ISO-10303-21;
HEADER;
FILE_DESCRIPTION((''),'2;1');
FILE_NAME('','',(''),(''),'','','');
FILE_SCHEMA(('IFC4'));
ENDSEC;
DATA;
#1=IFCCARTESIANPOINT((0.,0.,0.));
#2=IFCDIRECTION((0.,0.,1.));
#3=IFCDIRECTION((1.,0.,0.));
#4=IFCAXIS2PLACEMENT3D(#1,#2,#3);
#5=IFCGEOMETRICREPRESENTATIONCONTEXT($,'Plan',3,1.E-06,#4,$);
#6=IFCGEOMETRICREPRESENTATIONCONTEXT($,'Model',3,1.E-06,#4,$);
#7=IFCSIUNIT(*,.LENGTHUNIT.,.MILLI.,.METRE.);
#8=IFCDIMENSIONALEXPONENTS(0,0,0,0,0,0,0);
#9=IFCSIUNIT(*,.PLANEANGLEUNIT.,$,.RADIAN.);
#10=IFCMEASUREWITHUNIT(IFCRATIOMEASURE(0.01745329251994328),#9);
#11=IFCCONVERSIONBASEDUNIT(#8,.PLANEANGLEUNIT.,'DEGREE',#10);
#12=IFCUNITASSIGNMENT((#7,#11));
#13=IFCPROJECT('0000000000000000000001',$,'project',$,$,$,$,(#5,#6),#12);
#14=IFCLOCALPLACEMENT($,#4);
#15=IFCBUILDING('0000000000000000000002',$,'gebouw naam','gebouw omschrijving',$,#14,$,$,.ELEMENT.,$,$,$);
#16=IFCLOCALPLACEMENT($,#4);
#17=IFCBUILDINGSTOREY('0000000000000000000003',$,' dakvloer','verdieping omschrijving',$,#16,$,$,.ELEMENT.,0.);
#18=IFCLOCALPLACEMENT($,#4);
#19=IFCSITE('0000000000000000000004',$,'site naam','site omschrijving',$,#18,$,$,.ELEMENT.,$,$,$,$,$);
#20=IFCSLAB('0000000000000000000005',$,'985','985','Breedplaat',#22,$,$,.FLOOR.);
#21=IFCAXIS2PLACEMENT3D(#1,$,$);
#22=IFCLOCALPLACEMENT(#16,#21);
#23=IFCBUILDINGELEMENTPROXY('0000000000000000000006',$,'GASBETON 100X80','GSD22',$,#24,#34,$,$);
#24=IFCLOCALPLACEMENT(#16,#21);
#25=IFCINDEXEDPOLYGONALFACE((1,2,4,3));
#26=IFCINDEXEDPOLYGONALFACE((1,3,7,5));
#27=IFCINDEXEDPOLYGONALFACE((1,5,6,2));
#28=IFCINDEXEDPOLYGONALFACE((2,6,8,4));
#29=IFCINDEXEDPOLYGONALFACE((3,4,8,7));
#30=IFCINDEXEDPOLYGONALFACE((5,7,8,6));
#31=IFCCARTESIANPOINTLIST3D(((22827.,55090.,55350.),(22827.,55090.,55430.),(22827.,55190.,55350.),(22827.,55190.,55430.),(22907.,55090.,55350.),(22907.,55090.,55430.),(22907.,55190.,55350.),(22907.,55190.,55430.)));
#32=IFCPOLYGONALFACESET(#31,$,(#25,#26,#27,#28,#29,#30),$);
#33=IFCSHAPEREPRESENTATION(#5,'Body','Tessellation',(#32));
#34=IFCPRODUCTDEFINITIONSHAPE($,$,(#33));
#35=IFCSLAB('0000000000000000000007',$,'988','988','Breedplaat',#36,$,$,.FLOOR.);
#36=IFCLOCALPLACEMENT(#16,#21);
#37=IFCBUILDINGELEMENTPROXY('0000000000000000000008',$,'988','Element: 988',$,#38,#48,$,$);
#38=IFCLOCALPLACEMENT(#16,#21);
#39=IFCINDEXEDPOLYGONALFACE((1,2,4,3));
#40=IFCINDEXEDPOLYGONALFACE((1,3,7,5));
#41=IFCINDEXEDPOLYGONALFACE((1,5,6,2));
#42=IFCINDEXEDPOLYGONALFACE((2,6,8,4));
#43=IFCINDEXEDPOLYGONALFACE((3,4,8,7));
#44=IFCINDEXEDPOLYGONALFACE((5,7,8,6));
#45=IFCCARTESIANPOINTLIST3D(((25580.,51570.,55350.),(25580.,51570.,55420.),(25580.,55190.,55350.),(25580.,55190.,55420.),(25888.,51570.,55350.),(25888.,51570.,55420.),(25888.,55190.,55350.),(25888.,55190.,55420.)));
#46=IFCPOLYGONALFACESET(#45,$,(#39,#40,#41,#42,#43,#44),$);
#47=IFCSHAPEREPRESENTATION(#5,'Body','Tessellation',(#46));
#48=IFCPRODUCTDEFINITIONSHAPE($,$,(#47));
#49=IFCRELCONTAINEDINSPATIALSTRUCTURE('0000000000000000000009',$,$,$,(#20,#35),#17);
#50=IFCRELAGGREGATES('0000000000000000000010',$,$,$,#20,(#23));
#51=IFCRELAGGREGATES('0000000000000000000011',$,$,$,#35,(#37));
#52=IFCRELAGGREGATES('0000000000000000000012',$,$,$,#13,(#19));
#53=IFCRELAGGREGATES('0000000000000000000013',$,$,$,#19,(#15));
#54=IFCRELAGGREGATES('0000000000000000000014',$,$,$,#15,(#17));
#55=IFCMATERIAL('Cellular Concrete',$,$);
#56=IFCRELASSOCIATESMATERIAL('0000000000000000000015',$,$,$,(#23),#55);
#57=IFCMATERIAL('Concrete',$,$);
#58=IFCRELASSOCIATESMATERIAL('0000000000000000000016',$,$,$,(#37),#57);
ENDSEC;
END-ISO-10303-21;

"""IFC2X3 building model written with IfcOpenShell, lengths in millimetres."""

from ifc_helpers import new_model, entity, si_unit, converted_unit, frame, origin_with_axes, origin_2d_with_axis, place, context, project, spatial, polyline, rectangle, outline, extrude, material, element, aggregate, save


model = new_model("IFC2X3")

# Units and contexts
plan_context = context("Plan", 3, precision=1e-06, world=origin_with_axes())
model_context = context("Model", 3, precision=1e-06, world=origin_with_axes())
ifc_project = project(units=[si_unit("LENGTHUNIT", "METRE", prefix="MILLI"), converted_unit("PLANEANGLEUNIT", "DEGREE", entity("IfcRatioMeasure", 0.01745329251994328), si_unit("PLANEANGLEUNIT", "RADIAN"), dimensions=[0, 0, 0, 0, 0, 0, 0])], contexts=[plan_context, model_context])

# Site, building, storey
site_placement = place(None, origin_with_axes())
site = spatial("IfcSite", under=ifc_project, at=site_placement, Name="site naam", Description="site omschrijving", CompositionType="ELEMENT")
building_placement = place(None, origin_with_axes())
building = spatial("IfcBuilding", under=site, at=building_placement, Name="gebouw naam", Description="gebouw omschrijving", CompositionType="ELEMENT")
storey_placement = place(None, origin_with_axes())
storey = spatial("IfcBuildingStorey", under=building, at=storey_placement, Name=" dakvloer", Description="verdieping omschrijving", CompositionType="ELEMENT", Elevation=0.0)

# Slab, building element proxy
slab_1_placement = place(None, frame((22730.0, 55190.0, 55350.0), z_axis=(0.0, 0.0, 1.0), x_axis=(0.0, -1.0, 0.0)))
slab_1 = element("IfcSlab", 1, at=slab_1_placement, inside=storey, Name="985", Description="985", ObjectType="Breedplaat", PredefinedType="FLOOR")
ifc_material_1 = material(Name="Cellular Concrete")
proxy_1_placement = place(slab_1_placement, frame((50.0, 137.0, 0.0), z_axis=(0.0, 0.0, 1.0), x_axis=(1.0, 0.0, 0.0)))
proxy_1 = element("IfcBuildingElementProxy", 2, at=proxy_1_placement, material=ifc_material_1, Name="GASBETON 100X80", Description="GSD22", context=plan_context, shape_type="SweptSolid", body=[
    extrude(rectangle(XDim=100.0, YDim=80.0, at=origin_2d_with_axis()), origin_with_axes(), (0.0, 0.0, 1.0), 80.0),
])
aggregate(slab_1, [proxy_1])

# Slab, building element proxy, opening
slab_2_placement = place(None, frame((25580.0, 55190.0, 55350.0), z_axis=(0.0, 0.0, 1.0), x_axis=(0.0, -1.0, 0.0)))
slab_2 = element("IfcSlab", 3, at=slab_2_placement, inside=storey, Name="988", Description="988", ObjectType="Breedplaat", PredefinedType="FLOOR")
ifc_material_2 = material(Name="Concrete")
proxy_2_placement = place(slab_2_placement, origin_with_axes())
proxy_2 = element("IfcBuildingElementProxy", 4, at=proxy_2_placement, material=ifc_material_2, Name="988", Description="Element: 988", context=plan_context, shape_type="SweptSolid", body=[
    extrude(outline(polyline([(3620.0, 0.0), (3620.0, 308.0), (0.0, 308.0), (0.0, 0.0), (3620.0, 0.0)])), origin_with_axes(), (0.0, 0.0, 1.0), 70.0),
])
opening_1_placement = place(None, frame((25580.0, 55190.0, 55350.0), z_axis=(0.0, 0.0, 1.0), x_axis=(0.0, -1.0, 0.0)))
element("IfcOpeningElement", 5, at=opening_1_placement, cuts=proxy_2, ObjectType="Opening", context=plan_context, shape_type="SweptSolid", body=[
    extrude(outline(polyline([(-0.1, -0.1), (-0.1, 10.0), (10.0, -0.1), (-0.1, -0.1)])), frame((3621.2, 308.2, -0.1), z_axis=(-1.0, 0.0, 0.0), x_axis=(0.0, -1.0, 0.0)), (0.0, 0.0, 1.0), 3622.2),
])
aggregate(slab_2, [proxy_2])

save(model, "model.ifc")
